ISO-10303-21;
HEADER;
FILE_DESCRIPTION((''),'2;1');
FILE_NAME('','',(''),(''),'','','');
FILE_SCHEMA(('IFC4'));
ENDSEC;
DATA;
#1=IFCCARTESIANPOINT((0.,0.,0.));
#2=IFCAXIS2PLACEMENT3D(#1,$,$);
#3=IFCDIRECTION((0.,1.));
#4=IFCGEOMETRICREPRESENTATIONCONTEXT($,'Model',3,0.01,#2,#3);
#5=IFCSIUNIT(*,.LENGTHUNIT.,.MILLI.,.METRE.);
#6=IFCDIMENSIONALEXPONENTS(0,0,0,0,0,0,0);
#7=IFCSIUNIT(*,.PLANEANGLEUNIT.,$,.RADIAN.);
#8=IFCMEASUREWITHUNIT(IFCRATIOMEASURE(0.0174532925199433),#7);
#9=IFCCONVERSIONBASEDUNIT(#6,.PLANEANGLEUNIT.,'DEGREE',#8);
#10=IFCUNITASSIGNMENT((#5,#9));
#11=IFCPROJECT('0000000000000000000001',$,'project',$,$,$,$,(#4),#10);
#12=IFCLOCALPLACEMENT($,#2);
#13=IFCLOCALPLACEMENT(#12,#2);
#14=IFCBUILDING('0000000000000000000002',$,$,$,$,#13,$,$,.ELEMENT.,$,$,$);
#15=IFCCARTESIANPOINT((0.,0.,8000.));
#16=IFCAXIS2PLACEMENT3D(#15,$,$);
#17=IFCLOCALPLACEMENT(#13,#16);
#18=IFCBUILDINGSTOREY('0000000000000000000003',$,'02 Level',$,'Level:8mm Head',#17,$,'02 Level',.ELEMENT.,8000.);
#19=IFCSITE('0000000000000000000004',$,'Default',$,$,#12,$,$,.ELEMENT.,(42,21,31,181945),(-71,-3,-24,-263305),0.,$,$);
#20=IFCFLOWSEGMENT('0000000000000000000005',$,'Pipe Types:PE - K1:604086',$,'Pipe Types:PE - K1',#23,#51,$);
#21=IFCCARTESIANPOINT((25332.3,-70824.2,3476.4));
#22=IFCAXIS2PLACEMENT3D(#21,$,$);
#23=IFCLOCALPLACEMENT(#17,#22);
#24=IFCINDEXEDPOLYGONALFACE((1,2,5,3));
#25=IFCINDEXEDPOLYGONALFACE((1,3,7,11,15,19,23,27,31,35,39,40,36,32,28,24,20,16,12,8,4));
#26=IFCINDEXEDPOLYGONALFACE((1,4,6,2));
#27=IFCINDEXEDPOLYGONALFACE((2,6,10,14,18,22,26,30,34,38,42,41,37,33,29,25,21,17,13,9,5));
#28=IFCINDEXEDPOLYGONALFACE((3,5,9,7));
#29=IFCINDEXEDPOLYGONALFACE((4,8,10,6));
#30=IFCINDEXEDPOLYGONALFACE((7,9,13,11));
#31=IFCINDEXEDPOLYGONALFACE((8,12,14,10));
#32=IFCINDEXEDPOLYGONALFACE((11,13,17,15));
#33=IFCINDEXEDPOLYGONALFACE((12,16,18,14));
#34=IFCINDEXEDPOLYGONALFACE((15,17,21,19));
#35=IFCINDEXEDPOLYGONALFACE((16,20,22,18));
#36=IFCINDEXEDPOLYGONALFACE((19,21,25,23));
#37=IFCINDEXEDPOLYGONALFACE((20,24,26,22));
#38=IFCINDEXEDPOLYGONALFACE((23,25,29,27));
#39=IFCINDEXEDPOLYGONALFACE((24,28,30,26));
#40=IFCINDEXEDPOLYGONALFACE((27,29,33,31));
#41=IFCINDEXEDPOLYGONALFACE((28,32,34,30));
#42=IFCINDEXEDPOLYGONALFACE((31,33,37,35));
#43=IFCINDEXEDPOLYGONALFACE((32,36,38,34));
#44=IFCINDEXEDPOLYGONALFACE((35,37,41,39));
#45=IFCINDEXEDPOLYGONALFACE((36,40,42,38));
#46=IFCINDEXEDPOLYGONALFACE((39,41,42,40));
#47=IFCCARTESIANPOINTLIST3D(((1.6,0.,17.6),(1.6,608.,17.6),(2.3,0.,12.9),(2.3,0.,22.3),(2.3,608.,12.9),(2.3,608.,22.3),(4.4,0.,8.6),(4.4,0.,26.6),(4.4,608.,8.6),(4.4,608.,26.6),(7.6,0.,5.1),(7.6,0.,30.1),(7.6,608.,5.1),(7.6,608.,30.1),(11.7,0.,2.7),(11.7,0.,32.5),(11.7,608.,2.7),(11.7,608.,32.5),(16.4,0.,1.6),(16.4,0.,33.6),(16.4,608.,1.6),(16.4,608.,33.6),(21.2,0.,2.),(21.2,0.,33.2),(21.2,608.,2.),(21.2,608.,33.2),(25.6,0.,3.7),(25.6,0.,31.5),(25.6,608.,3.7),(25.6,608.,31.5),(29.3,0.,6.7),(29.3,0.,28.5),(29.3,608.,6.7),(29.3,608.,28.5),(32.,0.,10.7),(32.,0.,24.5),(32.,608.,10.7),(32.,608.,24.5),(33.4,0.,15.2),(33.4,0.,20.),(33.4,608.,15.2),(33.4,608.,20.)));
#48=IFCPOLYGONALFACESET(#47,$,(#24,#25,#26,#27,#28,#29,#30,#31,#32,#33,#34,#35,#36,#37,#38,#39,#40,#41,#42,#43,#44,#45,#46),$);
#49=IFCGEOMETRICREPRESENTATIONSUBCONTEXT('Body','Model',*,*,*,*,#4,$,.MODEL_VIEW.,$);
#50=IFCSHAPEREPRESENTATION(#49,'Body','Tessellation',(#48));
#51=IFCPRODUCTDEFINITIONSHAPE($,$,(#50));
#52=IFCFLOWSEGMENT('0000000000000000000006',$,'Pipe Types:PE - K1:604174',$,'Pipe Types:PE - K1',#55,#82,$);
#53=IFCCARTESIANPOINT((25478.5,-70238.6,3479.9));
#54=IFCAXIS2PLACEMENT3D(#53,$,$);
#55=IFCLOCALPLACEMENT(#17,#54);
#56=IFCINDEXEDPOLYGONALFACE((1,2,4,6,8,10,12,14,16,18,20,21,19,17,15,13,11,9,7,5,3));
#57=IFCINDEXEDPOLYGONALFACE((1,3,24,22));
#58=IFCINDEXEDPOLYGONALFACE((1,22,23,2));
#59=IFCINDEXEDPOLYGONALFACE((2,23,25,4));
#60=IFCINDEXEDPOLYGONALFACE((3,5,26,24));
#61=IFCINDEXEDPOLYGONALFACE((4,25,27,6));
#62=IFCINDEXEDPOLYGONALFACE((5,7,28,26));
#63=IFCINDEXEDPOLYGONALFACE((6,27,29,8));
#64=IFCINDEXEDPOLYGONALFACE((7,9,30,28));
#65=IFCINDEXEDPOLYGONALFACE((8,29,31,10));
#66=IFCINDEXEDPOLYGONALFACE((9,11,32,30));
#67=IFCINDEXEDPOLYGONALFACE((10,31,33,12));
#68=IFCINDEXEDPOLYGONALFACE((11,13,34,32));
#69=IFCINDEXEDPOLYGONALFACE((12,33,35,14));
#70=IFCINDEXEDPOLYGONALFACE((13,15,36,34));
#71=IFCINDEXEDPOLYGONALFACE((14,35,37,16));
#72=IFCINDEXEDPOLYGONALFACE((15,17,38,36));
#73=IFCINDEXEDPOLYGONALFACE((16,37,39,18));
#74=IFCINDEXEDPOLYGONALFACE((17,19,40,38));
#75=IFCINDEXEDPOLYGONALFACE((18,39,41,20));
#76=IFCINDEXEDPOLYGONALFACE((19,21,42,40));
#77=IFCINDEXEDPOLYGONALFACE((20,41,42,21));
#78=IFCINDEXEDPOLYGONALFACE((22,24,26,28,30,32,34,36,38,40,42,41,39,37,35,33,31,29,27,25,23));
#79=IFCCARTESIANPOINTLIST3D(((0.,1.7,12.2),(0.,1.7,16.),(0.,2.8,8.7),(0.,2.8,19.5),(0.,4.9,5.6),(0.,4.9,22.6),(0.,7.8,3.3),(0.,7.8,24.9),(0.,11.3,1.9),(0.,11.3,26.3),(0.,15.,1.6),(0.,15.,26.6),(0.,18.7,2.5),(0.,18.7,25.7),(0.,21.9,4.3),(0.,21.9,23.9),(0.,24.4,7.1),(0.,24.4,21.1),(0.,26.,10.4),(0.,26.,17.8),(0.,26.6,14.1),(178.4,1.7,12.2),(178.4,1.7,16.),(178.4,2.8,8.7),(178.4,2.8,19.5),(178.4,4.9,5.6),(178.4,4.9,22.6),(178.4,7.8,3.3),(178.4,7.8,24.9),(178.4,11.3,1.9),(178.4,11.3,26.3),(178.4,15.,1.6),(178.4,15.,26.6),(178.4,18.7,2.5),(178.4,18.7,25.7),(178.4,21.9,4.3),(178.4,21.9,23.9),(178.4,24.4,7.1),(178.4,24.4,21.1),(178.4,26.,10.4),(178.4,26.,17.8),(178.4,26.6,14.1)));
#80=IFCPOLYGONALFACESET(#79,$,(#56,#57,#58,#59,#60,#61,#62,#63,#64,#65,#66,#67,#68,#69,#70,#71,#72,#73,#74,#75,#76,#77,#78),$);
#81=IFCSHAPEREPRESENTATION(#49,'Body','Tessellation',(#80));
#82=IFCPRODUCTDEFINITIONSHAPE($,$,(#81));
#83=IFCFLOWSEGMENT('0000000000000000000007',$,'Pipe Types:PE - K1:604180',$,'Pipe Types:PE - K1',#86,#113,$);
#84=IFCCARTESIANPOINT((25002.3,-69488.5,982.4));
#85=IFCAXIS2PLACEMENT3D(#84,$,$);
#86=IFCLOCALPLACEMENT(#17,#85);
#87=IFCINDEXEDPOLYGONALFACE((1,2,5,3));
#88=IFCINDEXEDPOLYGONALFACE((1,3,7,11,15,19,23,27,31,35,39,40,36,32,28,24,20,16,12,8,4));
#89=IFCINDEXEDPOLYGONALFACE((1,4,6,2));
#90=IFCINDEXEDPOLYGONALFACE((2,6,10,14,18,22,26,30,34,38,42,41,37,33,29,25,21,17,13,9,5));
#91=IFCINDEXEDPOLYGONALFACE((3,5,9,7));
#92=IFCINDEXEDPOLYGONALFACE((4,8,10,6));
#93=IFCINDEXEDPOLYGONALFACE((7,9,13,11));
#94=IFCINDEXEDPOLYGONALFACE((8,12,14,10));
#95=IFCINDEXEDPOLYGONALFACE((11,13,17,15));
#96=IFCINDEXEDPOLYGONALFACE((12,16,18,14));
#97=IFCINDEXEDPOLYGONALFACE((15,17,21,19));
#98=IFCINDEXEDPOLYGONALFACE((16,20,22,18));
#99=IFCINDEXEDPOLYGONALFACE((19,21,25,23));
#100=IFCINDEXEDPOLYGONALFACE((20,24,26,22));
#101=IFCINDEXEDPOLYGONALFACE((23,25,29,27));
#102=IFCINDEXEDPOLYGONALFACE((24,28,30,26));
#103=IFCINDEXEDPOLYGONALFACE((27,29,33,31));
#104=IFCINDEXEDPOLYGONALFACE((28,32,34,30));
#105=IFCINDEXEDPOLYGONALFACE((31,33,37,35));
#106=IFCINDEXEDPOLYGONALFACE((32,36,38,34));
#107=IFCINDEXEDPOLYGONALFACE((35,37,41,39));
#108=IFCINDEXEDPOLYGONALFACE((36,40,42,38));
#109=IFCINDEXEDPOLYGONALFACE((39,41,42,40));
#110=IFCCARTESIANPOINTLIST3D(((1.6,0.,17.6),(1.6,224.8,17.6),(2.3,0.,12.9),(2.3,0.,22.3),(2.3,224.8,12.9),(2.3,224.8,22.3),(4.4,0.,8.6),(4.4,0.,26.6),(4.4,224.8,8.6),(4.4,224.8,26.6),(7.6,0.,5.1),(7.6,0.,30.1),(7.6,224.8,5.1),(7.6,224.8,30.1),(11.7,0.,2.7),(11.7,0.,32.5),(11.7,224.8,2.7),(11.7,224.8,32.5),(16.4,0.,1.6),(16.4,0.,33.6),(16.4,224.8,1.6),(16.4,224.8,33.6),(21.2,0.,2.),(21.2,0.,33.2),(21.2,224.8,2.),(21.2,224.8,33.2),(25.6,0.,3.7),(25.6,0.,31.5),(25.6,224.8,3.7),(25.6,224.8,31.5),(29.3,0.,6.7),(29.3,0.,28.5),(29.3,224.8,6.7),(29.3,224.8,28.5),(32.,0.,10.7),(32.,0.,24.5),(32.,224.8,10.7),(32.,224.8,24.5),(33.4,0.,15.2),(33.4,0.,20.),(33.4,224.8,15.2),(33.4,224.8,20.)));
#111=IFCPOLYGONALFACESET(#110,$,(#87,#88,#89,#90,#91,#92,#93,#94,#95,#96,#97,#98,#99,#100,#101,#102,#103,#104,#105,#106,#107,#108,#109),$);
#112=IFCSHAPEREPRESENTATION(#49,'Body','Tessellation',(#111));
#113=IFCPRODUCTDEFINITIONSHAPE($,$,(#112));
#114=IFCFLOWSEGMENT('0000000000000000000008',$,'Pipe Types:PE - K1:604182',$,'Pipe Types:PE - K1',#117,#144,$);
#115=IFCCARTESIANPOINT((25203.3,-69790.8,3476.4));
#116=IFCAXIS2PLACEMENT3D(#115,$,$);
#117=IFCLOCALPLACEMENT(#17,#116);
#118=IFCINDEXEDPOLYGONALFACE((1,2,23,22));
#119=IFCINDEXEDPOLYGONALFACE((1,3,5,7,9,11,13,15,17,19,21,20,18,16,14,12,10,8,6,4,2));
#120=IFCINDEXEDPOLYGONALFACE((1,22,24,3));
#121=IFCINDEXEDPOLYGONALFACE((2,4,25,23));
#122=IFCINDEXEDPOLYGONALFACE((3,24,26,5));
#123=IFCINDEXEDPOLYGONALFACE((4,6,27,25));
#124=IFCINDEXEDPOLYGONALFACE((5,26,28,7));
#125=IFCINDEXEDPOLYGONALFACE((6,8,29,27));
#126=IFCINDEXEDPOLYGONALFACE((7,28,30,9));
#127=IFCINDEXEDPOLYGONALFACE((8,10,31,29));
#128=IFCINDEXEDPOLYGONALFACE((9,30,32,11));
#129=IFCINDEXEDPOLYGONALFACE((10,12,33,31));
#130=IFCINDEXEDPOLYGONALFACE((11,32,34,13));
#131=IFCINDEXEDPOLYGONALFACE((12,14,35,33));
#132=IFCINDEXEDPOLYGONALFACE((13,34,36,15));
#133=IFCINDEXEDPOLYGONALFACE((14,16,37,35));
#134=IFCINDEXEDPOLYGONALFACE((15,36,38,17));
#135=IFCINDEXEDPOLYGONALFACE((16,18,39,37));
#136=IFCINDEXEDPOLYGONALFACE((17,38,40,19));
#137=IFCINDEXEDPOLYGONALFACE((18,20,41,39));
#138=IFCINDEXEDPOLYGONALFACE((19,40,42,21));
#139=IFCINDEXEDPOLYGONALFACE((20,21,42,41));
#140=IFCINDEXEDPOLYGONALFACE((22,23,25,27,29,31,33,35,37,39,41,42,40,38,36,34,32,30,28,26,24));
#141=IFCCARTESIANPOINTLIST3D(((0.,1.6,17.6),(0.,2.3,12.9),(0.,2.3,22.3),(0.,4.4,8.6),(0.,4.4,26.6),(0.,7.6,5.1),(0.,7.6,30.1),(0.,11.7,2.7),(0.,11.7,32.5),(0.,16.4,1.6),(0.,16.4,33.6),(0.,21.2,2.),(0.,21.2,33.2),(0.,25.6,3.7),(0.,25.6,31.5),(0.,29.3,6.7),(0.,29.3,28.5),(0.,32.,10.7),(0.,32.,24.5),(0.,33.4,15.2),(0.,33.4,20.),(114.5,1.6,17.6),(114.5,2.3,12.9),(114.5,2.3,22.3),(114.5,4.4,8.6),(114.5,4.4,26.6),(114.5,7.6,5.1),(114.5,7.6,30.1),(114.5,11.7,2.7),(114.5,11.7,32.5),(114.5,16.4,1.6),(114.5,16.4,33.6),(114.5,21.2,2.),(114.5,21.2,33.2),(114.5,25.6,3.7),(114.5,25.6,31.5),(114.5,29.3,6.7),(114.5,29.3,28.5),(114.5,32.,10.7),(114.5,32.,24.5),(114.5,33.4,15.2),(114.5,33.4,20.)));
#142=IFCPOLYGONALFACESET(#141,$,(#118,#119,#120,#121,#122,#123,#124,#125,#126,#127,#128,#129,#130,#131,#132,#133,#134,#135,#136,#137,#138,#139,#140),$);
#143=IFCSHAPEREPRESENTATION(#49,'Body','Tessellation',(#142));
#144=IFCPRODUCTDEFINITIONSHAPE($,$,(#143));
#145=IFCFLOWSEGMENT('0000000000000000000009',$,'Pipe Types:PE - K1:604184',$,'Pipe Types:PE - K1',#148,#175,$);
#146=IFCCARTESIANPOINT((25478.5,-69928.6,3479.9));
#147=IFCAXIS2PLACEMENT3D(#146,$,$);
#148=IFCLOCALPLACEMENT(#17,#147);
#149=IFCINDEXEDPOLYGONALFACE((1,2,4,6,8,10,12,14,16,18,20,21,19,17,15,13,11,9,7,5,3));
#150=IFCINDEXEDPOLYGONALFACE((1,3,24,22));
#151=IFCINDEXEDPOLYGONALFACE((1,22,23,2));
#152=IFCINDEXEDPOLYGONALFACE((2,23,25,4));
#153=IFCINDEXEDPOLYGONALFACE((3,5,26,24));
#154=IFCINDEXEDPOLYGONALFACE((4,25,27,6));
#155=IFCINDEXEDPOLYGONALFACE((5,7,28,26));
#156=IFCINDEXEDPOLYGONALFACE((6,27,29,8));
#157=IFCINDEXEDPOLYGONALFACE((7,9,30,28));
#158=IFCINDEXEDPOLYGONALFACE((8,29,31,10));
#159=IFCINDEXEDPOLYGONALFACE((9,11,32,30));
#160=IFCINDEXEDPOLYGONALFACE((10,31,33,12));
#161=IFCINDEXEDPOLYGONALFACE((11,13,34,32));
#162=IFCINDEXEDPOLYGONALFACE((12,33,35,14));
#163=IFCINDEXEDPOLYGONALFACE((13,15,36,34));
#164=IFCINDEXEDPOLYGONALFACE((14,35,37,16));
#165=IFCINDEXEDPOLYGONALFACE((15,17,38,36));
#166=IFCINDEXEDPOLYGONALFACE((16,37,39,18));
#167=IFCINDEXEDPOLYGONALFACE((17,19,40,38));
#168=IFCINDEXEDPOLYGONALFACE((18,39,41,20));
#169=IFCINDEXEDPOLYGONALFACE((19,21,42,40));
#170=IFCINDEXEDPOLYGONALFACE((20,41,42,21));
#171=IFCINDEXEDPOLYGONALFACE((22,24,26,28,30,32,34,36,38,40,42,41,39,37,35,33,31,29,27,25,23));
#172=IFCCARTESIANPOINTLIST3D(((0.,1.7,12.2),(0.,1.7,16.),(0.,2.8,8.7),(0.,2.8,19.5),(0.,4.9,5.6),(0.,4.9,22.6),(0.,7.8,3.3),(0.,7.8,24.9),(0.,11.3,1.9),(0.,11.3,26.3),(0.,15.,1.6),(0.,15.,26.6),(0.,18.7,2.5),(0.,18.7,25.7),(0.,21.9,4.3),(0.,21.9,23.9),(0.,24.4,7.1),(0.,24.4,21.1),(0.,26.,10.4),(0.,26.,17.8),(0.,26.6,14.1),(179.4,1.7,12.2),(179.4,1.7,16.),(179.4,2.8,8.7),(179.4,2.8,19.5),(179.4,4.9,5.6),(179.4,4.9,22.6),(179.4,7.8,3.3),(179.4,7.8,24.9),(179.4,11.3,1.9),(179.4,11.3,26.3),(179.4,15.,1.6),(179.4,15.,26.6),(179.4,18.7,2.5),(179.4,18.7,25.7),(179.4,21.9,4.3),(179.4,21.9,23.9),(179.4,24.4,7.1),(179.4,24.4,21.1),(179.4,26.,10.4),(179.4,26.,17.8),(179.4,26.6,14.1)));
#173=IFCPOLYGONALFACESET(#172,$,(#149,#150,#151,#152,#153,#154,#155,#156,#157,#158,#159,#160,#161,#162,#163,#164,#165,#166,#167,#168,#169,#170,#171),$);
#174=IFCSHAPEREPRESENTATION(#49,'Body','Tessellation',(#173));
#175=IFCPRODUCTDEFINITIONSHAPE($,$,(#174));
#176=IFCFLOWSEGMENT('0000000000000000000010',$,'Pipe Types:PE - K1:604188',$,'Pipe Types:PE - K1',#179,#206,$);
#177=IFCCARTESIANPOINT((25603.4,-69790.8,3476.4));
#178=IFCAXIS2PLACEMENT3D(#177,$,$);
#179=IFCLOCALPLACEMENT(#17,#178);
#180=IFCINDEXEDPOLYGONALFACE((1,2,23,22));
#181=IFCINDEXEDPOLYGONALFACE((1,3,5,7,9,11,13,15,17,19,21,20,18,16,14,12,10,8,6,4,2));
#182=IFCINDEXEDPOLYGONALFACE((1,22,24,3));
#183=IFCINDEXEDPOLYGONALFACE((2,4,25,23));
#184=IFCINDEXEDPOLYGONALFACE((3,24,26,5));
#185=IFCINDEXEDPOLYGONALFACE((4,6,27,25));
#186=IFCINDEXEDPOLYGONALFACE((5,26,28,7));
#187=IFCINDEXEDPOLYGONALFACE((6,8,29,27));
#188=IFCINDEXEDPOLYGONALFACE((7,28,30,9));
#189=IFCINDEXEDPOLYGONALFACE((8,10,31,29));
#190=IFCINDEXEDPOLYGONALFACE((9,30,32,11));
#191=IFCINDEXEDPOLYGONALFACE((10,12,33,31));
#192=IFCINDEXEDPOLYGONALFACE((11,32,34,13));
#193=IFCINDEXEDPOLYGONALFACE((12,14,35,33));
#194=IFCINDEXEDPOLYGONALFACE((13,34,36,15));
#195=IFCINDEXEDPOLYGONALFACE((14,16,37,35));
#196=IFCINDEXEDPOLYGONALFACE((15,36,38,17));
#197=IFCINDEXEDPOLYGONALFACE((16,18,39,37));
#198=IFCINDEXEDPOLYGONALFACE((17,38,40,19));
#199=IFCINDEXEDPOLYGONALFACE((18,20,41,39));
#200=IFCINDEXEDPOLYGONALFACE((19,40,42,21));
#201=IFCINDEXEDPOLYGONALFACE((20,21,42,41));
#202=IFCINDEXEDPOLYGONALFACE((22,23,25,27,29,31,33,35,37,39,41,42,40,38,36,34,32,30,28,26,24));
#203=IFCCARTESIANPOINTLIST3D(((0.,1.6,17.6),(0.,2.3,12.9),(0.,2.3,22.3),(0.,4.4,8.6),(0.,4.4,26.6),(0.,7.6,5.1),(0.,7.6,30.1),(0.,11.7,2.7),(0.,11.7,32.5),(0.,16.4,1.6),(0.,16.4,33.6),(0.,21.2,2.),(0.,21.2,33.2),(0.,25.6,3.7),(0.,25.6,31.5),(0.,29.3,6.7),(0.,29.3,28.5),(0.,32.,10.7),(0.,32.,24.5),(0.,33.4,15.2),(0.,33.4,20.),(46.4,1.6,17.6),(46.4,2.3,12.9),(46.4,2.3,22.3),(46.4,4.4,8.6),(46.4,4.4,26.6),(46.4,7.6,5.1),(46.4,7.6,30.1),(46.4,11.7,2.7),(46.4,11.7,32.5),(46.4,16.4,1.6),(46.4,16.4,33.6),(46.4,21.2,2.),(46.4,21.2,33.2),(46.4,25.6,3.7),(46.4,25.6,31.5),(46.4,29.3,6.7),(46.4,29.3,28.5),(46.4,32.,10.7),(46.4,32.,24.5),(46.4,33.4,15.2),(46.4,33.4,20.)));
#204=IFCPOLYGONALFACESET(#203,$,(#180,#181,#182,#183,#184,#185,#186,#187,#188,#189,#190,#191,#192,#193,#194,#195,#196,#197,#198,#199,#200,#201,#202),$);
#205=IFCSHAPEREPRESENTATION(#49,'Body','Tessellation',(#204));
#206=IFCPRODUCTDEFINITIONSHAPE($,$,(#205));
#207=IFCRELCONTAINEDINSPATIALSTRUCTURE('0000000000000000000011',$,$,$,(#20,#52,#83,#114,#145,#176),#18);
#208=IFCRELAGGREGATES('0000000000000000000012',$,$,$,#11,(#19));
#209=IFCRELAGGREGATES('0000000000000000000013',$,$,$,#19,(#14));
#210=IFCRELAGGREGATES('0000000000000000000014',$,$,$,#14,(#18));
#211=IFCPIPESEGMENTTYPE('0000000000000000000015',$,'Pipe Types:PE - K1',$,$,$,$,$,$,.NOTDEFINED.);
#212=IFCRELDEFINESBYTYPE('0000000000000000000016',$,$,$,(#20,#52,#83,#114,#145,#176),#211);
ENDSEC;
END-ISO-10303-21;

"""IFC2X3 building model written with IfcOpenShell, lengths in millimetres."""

from ifc_helpers import new_model, entity, si_unit, converted_unit, direction, frame, frame_2d, origin, origin_2d_with_axis, place, context, subcontext, project, spatial, circle, extrude, type_object, element, save


model = new_model("IFC2X3")

# Units and contexts
model_context = context("Model", 3, precision=0.01, world=origin(), true_north=direction((0.0, 1.0)))
body_context = subcontext(model_context, "Body", "Model", "MODEL_VIEW")
ifc_project = project(units=[si_unit("LENGTHUNIT", "METRE", prefix="MILLI"), converted_unit("PLANEANGLEUNIT", "DEGREE", entity("IfcRatioMeasure", 0.0174532925199433), si_unit("PLANEANGLEUNIT", "RADIAN"), dimensions=[0, 0, 0, 0, 0, 0, 0])], contexts=[model_context])

# Site, building, storey
site_placement = place(None, origin())
site = spatial("IfcSite", under=ifc_project, at=site_placement, Name="Default", CompositionType="ELEMENT", RefLatitude=(42, 21, 31, 181945), RefLongitude=(-71, -3, -24, -263305), RefElevation=0.0)
building_placement = place(site_placement, origin())
building = spatial("IfcBuilding", under=site, at=building_placement, CompositionType="ELEMENT")
storey_placement = place(building_placement, frame((0.0, 0.0, 8000.0)))
storey = spatial("IfcBuildingStorey", under=building, at=storey_placement, Name="02 Level", ObjectType="Level:8mm Head", LongName="02 Level", CompositionType="ELEMENT", Elevation=8000.0)

# Flow segments
pipe_segment_type = type_object("IfcPipeSegmentType", Name="Pipe Types:PE - K1", PredefinedType="NOTDEFINED")
flow_segment_1_placement = place(storey_placement, frame((25332.3, -70824.2, 3476.4)))
element("IfcFlowSegment", 1, at=flow_segment_1_placement, inside=storey, type_object=pipe_segment_type, Name="Pipe Types:PE - K1:604086", ObjectType="Pipe Types:PE - K1", context=body_context, shape_type="SweptSolid", body=[
    extrude(circle(Radius=16.0, at=frame_2d((0.0, 0.0), x_axis=(1.0, 0.0))), frame((17.6, 0.0, 17.6), z_axis=(0.0, 1.0, 0.0), x_axis=(-1.0, 0.0, 0.0)), (0.0, 0.0, 1.0), 608.0),
])
flow_segment_2_placement = place(storey_placement, frame((25478.5, -70238.6, 3479.9)))
element("IfcFlowSegment", 2, at=flow_segment_2_placement, inside=storey, type_object=pipe_segment_type, Name="Pipe Types:PE - K1:604174", ObjectType="Pipe Types:PE - K1", context=body_context, shape_type="SweptSolid", body=[
    extrude(circle(Radius=12.5, at=origin_2d_with_axis()), frame((0.0, 14.1, 14.1), z_axis=(1.0, 0.0, 0.0), x_axis=(0.0, 1.0, 0.0)), (0.0, 0.0, 1.0), 178.4),
])
flow_segment_3_placement = place(storey_placement, frame((25002.3, -69488.5, 982.4)))
element("IfcFlowSegment", 3, at=flow_segment_3_placement, inside=storey, type_object=pipe_segment_type, Name="Pipe Types:PE - K1:604180", ObjectType="Pipe Types:PE - K1", context=body_context, shape_type="SweptSolid", body=[
    extrude(circle(Radius=16.0, at=origin_2d_with_axis()), frame((17.6, 0.0, 17.6), z_axis=(0.0, 1.0, 0.0), x_axis=(-1.0, 0.0, 0.0)), (0.0, 0.0, 1.0), 224.8),
])
flow_segment_4_placement = place(storey_placement, frame((25203.3, -69790.8, 3476.4)))
element("IfcFlowSegment", 4, at=flow_segment_4_placement, inside=storey, type_object=pipe_segment_type, Name="Pipe Types:PE - K1:604182", ObjectType="Pipe Types:PE - K1", context=body_context, shape_type="SweptSolid", body=[
    extrude(circle(Radius=16.0, at=origin_2d_with_axis()), frame((0.0, 17.6, 17.6), z_axis=(1.0, 0.0, 0.0), x_axis=(0.0, -1.0, 0.0)), (0.0, 0.0, 1.0), 114.5),
])
flow_segment_5_placement = place(storey_placement, frame((25478.5, -69928.6, 3479.9)))
element("IfcFlowSegment", 5, at=flow_segment_5_placement, inside=storey, type_object=pipe_segment_type, Name="Pipe Types:PE - K1:604184", ObjectType="Pipe Types:PE - K1", context=body_context, shape_type="SweptSolid", body=[
    extrude(circle(Radius=12.5, at=origin_2d_with_axis()), frame((0.0, 14.1, 14.1), z_axis=(1.0, 0.0, 0.0), x_axis=(0.0, 1.0, 0.0)), (0.0, 0.0, 1.0), 179.4),
])
flow_segment_6_placement = place(storey_placement, frame((25603.4, -69790.8, 3476.4)))
element("IfcFlowSegment", 6, at=flow_segment_6_placement, inside=storey, type_object=pipe_segment_type, Name="Pipe Types:PE - K1:604188", ObjectType="Pipe Types:PE - K1", context=body_context, shape_type="SweptSolid", body=[
    extrude(circle(Radius=16.0, at=origin_2d_with_axis()), frame((0.0, 17.6, 17.6), z_axis=(1.0, 0.0, 0.0), x_axis=(0.0, -1.0, 0.0)), (0.0, 0.0, 1.0), 46.4),
])

save(model, "model.ifc")
